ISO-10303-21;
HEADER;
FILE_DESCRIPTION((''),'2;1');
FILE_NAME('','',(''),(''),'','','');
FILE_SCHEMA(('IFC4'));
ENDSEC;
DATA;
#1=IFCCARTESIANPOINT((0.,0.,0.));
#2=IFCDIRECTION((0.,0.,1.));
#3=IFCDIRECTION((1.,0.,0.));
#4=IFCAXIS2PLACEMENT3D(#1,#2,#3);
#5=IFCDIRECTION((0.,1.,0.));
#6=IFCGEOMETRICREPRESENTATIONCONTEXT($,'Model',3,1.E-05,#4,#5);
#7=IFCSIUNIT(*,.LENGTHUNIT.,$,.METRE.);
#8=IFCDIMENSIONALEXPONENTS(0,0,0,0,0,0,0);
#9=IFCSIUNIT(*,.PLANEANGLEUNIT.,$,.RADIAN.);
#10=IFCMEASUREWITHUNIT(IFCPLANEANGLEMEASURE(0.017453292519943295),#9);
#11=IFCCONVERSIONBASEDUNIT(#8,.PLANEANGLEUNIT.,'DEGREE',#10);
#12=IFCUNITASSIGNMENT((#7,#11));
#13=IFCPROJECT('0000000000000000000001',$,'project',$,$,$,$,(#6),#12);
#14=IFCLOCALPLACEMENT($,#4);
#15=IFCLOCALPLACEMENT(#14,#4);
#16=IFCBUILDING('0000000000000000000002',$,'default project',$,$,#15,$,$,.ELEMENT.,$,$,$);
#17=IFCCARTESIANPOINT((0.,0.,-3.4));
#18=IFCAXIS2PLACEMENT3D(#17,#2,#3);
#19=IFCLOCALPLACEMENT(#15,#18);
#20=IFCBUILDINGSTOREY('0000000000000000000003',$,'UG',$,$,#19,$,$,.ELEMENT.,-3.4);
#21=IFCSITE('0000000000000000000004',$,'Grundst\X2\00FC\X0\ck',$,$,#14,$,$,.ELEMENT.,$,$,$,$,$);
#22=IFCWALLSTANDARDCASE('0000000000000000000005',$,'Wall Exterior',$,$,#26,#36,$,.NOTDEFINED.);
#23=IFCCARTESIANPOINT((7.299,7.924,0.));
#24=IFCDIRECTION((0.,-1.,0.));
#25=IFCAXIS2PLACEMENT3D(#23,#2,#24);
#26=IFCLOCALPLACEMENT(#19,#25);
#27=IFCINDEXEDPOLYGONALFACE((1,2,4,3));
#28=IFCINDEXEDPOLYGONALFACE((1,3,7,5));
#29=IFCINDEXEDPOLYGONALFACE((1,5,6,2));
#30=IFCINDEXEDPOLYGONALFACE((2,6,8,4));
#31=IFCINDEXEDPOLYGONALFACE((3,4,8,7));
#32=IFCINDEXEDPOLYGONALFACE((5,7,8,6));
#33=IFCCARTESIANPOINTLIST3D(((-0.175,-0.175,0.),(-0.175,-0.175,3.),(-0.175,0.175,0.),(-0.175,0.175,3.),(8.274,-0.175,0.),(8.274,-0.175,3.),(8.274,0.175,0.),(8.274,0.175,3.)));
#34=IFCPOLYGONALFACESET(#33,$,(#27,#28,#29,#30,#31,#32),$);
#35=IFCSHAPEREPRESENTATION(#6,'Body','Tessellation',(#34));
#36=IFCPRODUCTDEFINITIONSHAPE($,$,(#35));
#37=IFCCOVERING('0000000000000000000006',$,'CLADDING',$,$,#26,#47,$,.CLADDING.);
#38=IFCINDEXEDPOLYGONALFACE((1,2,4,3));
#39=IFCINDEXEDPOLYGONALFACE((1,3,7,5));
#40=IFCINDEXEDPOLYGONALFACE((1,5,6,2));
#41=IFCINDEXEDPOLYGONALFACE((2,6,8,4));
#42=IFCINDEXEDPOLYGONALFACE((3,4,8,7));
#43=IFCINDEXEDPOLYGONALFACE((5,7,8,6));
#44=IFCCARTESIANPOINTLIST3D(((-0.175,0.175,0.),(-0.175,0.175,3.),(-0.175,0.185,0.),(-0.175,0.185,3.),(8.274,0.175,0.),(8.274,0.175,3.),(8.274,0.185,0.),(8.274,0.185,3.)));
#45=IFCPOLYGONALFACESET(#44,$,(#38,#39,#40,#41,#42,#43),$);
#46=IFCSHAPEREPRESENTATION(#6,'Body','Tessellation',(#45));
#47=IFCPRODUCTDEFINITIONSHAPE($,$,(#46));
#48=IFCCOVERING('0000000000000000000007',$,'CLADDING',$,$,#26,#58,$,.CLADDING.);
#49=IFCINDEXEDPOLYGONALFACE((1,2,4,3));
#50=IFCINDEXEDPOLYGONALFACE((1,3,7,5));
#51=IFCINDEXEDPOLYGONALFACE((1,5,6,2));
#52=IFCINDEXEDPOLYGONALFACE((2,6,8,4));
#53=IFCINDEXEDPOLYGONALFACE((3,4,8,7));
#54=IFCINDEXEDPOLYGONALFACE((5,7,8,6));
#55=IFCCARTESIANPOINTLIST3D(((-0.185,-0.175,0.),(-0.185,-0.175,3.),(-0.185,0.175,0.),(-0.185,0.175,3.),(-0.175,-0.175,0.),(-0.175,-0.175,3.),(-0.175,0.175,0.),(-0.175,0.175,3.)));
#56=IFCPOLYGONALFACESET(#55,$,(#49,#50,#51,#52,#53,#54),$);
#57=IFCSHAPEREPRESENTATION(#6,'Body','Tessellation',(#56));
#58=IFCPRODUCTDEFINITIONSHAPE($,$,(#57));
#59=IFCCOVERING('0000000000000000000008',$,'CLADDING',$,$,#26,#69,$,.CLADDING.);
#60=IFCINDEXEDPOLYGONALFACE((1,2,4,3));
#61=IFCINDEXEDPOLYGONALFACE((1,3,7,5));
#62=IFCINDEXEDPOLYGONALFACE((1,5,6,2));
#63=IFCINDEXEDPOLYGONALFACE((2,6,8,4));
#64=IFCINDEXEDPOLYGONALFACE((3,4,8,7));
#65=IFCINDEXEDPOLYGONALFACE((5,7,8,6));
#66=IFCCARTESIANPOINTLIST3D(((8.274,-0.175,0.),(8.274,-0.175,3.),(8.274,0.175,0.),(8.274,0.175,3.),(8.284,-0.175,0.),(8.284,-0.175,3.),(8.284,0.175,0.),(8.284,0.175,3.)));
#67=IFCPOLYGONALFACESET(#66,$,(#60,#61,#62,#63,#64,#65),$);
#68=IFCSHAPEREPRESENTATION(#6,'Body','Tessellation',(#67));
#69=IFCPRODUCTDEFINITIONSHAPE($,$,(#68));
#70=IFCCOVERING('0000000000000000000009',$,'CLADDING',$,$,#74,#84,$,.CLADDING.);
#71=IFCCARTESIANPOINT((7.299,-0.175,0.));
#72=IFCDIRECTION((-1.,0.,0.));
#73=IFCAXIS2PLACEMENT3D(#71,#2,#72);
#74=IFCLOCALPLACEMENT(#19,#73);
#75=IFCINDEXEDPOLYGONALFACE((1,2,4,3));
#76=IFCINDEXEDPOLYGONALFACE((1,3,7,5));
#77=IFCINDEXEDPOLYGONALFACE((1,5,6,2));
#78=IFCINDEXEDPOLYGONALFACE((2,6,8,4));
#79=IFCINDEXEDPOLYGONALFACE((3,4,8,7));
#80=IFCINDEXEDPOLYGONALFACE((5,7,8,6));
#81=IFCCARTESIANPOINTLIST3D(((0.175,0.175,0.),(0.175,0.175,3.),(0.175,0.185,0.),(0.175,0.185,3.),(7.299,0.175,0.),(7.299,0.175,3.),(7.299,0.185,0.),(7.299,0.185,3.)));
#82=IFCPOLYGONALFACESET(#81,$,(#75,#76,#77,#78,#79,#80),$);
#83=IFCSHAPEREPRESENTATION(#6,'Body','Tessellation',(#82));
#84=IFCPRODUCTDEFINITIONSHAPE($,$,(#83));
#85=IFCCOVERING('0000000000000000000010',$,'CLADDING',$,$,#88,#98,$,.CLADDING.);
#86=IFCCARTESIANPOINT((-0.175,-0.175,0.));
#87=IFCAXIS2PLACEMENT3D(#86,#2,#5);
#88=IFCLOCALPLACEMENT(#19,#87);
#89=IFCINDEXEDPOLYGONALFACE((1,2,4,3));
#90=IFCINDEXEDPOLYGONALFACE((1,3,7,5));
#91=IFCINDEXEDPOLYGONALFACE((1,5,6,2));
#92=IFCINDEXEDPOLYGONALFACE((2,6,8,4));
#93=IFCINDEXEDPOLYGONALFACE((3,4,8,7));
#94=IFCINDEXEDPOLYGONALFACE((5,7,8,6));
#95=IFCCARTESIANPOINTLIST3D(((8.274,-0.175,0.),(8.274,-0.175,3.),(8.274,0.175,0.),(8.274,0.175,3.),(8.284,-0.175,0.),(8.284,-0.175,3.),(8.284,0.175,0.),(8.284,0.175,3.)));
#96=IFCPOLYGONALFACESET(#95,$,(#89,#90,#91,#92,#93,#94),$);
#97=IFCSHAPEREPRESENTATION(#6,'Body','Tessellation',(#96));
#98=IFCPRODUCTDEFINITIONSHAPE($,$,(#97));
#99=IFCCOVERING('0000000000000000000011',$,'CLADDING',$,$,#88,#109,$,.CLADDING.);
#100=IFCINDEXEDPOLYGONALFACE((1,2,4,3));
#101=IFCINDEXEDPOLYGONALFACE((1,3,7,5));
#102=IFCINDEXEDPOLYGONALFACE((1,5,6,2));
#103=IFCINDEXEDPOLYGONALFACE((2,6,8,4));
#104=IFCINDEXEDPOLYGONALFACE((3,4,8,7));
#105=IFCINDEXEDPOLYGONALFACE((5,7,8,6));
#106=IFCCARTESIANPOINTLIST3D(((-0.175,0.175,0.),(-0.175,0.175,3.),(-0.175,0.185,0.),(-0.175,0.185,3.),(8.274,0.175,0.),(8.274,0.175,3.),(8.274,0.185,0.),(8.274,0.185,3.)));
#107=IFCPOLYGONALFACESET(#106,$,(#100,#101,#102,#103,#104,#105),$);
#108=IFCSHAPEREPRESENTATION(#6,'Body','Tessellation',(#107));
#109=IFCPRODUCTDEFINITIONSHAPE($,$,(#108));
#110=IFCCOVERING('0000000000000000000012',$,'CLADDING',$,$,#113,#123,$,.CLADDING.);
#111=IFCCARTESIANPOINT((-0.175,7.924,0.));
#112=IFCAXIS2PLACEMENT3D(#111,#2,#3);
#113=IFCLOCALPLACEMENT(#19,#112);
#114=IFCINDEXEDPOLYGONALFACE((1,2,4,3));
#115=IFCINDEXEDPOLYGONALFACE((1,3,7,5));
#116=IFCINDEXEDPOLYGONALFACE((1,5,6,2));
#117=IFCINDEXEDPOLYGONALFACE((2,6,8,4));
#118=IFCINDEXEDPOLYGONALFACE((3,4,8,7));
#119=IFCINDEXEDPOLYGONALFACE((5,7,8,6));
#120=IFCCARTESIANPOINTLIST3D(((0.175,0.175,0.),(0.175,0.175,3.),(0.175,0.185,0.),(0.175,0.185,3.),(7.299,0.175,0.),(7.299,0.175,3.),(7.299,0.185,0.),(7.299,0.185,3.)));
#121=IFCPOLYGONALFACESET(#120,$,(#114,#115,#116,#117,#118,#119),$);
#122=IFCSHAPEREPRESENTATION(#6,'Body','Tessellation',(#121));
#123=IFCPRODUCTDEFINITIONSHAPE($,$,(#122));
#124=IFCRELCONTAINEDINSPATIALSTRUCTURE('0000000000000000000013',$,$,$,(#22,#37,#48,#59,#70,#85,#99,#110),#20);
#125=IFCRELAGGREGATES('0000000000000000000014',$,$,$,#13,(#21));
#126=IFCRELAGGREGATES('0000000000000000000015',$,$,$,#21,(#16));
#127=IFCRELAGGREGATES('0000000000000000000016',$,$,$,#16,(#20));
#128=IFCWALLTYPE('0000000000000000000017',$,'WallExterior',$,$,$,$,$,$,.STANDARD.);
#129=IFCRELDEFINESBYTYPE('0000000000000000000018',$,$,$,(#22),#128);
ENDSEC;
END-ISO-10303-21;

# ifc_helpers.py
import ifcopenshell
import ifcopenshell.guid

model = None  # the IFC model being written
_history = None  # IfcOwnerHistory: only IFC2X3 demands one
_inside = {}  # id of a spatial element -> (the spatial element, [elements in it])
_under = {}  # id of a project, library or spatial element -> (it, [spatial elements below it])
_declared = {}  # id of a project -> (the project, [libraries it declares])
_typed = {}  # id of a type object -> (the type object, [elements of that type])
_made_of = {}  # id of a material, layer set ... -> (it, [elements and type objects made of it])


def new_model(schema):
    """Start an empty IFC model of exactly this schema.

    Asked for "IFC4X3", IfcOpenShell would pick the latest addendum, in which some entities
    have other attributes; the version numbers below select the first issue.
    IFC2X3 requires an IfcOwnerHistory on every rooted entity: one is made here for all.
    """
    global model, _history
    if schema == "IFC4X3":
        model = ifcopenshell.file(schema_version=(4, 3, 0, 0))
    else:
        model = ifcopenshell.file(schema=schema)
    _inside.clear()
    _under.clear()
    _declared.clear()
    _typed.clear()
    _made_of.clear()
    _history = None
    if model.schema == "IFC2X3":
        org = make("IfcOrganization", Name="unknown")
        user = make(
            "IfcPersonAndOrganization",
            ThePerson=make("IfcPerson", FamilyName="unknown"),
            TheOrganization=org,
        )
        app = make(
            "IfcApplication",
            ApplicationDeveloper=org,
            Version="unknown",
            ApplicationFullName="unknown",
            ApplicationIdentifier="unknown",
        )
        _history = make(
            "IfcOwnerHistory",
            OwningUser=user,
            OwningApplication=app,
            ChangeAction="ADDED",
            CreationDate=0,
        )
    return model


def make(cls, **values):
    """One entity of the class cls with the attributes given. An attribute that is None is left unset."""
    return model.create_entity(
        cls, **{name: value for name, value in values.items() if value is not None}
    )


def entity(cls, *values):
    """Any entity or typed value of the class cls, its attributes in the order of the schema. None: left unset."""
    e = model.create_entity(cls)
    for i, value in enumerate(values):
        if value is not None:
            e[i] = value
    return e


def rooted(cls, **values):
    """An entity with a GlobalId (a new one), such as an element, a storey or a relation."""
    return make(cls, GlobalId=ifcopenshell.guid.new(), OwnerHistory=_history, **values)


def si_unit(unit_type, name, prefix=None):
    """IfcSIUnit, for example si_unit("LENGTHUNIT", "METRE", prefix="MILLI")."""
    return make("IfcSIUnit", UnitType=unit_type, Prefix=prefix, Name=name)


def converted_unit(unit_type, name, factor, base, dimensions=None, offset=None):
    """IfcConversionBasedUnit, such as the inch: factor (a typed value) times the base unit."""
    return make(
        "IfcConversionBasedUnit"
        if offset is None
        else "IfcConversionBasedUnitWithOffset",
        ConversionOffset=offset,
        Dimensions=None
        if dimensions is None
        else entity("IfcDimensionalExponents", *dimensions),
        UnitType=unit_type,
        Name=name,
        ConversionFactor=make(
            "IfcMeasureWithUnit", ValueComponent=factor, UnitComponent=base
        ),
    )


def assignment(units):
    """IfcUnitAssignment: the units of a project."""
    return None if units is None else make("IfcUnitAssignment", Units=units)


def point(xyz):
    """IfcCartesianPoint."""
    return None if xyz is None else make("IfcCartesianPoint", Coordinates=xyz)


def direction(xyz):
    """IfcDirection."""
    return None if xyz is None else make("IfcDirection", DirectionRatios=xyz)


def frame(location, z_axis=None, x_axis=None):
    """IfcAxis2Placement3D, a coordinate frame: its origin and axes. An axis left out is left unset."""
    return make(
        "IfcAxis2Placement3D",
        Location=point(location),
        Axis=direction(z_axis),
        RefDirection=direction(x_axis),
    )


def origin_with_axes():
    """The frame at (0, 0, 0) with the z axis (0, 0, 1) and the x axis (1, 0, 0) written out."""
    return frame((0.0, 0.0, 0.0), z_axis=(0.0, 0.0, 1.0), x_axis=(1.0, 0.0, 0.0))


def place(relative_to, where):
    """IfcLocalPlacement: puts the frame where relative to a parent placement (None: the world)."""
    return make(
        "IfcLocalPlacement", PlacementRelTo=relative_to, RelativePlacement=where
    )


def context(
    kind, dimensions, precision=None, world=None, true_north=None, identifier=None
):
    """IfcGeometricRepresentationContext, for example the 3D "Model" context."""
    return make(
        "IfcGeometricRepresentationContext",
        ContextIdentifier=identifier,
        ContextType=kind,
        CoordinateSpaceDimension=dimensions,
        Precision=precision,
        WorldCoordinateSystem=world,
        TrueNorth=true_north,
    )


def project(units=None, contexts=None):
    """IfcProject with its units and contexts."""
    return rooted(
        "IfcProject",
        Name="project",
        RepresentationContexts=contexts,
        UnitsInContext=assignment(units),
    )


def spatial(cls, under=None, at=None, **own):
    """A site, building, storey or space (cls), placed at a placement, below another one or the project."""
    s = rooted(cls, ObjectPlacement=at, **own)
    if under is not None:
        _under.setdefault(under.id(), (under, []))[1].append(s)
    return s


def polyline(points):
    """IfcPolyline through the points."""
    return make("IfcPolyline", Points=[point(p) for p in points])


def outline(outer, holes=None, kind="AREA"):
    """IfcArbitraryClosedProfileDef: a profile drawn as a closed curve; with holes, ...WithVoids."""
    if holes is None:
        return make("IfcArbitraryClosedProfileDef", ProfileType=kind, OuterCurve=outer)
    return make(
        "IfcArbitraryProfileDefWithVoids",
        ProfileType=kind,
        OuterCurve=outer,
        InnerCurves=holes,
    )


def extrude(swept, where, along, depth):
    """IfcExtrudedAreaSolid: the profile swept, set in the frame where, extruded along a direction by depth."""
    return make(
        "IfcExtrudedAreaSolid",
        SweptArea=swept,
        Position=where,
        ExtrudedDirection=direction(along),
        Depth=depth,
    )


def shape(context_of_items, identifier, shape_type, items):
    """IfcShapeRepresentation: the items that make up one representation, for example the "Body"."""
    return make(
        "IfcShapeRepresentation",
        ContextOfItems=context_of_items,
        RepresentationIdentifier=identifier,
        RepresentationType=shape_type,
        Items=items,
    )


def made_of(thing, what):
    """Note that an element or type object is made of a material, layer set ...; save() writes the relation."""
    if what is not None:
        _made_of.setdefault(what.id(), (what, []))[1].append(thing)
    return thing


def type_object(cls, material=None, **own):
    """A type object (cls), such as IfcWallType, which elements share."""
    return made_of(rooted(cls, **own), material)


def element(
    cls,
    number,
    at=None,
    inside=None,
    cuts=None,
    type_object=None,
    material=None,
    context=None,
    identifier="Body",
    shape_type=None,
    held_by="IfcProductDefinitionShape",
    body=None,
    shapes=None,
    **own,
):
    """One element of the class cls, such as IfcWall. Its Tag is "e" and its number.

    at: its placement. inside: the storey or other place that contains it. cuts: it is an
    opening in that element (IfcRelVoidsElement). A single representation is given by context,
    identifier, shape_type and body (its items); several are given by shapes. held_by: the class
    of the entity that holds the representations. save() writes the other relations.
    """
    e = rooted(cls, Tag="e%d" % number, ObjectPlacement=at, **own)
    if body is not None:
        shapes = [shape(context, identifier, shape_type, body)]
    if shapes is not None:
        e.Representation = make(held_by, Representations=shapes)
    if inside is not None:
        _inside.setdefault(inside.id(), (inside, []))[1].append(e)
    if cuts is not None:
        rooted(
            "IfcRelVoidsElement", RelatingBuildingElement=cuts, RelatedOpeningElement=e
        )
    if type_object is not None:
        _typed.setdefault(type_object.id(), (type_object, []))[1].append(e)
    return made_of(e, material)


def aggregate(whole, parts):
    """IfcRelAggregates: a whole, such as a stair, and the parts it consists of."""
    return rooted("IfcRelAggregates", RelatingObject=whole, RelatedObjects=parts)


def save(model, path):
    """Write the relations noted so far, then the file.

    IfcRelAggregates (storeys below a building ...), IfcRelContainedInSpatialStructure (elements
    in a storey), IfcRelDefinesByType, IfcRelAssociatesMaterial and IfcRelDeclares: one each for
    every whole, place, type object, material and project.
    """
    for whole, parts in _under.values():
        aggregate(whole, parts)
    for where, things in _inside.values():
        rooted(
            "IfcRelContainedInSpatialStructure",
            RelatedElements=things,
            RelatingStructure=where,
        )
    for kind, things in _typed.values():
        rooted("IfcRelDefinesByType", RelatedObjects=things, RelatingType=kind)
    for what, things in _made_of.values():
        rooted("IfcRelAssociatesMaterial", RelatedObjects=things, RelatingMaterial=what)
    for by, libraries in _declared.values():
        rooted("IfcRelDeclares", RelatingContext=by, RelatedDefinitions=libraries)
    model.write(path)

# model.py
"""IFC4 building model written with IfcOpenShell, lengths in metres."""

from ifc_helpers import new_model, entity, si_unit, converted_unit, direction, frame, origin_with_axes, place, context, project, spatial, polyline, outline, extrude, type_object, element, save


model = new_model("IFC4")

# Units and contexts
model_context = context("Model", 3, precision=1e-05, world=origin_with_axes(), true_north=direction((0.0, 1.0, 0.0)))
ifc_project = project(units=[si_unit("LENGTHUNIT", "METRE"), converted_unit("PLANEANGLEUNIT", "DEGREE", entity("IfcPlaneAngleMeasure", 0.017453292519943295), si_unit("PLANEANGLEUNIT", "RADIAN"), dimensions=[0, 0, 0, 0, 0, 0, 0])], contexts=[model_context])

# Site, building, storey
site_placement = place(None, origin_with_axes())
site = spatial("IfcSite", under=ifc_project, at=site_placement, Name="Grundstück", CompositionType="ELEMENT")
building_placement = place(site_placement, origin_with_axes())
building = spatial("IfcBuilding", under=site, at=building_placement, Name="default project", CompositionType="ELEMENT")
placement_1 = place(building_placement, frame((0.0, 0.0, -3.4), z_axis=(0.0, 0.0, 1.0), x_axis=(1.0, 0.0, 0.0)))
storey = spatial("IfcBuildingStorey", under=building, at=placement_1, Name="UG", CompositionType="ELEMENT", Elevation=-3.4)

# Wall
wall_type = type_object("IfcWallType", Name="WallExterior", PredefinedType="STANDARD")
placement_2 = place(placement_1, frame((7.299, 7.924, 0.0), z_axis=(0.0, 0.0, 1.0), x_axis=(0.0, -1.0, 0.0)))
element("IfcWallStandardCase", 1, at=placement_2, inside=storey, type_object=wall_type, Name="Wall Exterior", PredefinedType="NOTDEFINED", context=model_context, shape_type="SweptSolid", body=[
    extrude(outline(polyline([(8.274, 0.175), (-0.175, 0.175), (-0.175, -0.175), (8.274, -0.175), (8.274, 0.175)])), origin_with_axes(), (0.0, 0.0, 1.0), 3.0),
])
placement_3 = place(placement_1, frame((7.299, -0.175, 0.0), z_axis=(0.0, 0.0, 1.0), x_axis=(-1.0, 0.0, 0.0)))
placement_4 = place(placement_1, frame((-0.175, -0.175, 0.0), z_axis=(0.0, 0.0, 1.0), x_axis=(0.0, 1.0, 0.0)))
placement_5 = place(placement_1, frame((-0.175, 7.924, 0.0), z_axis=(0.0, 0.0, 1.0), x_axis=(1.0, 0.0, 0.0)))

# Coverings
element("IfcCovering", 2, at=placement_2, inside=storey, Name="CLADDING", PredefinedType="CLADDING", context=model_context, shape_type="SweptSolid", body=[
    extrude(outline(polyline([(8.274, 0.185), (-0.175, 0.185), (-0.175, 0.175), (8.274, 0.175), (8.274, 0.185)])), origin_with_axes(), (0.0, 0.0, 1.0), 3.0),
])
element("IfcCovering", 3, at=placement_2, inside=storey, Name="CLADDING", PredefinedType="CLADDING", context=model_context, shape_type="SweptSolid", body=[
    extrude(outline(polyline([(-0.185, 0.175), (-0.185, -0.175), (-0.175, -0.175), (-0.175, 0.175), (-0.185, 0.175)])), origin_with_axes(), (0.0, 0.0, 1.0), 3.0),
])
element("IfcCovering", 4, at=placement_2, inside=storey, Name="CLADDING", PredefinedType="CLADDING", context=model_context, shape_type="SweptSolid", body=[
    extrude(outline(polyline([(8.284, -0.175), (8.284, 0.175), (8.274, 0.175), (8.274, -0.175), (8.284, -0.175)])), origin_with_axes(), (0.0, 0.0, 1.0), 3.0),
])
element("IfcCovering", 5, at=placement_3, inside=storey, Name="CLADDING", PredefinedType="CLADDING", context=model_context, shape_type="SweptSolid", body=[
    extrude(outline(polyline([(7.299, 0.185), (0.175, 0.185), (0.175, 0.175), (7.299, 0.175), (7.299, 0.185)])), origin_with_axes(), (0.0, 0.0, 1.0), 3.0),
])
element("IfcCovering", 6, at=placement_4, inside=storey, Name="CLADDING", PredefinedType="CLADDING", context=model_context, shape_type="SweptSolid", body=[
    extrude(outline(polyline([(8.284, -0.175), (8.284, 0.175), (8.274, 0.175), (8.274, -0.175), (8.284, -0.175)])), origin_with_axes(), (0.0, 0.0, 1.0), 3.0),
])
element("IfcCovering", 7, at=placement_4, inside=storey, Name="CLADDING", PredefinedType="CLADDING", context=model_context, shape_type="SweptSolid", body=[
    extrude(outline(polyline([(8.274, 0.185), (-0.175, 0.185), (-0.175, 0.175), (8.274, 0.175), (8.274, 0.185)])), origin_with_axes(), (0.0, 0.0, 1.0), 3.0),
])
element("IfcCovering", 8, at=placement_5, inside=storey, Name="CLADDING", PredefinedType="CLADDING", context=model_context, shape_type="SweptSolid", body=[
    extrude(outline(polyline([(7.299, 0.185), (0.175, 0.185), (0.175, 0.175), (7.299, 0.175), (7.299, 0.185)])), origin_with_axes(), (0.0, 0.0, 1.0), 3.0),
])

save(model, "model.ifc")
